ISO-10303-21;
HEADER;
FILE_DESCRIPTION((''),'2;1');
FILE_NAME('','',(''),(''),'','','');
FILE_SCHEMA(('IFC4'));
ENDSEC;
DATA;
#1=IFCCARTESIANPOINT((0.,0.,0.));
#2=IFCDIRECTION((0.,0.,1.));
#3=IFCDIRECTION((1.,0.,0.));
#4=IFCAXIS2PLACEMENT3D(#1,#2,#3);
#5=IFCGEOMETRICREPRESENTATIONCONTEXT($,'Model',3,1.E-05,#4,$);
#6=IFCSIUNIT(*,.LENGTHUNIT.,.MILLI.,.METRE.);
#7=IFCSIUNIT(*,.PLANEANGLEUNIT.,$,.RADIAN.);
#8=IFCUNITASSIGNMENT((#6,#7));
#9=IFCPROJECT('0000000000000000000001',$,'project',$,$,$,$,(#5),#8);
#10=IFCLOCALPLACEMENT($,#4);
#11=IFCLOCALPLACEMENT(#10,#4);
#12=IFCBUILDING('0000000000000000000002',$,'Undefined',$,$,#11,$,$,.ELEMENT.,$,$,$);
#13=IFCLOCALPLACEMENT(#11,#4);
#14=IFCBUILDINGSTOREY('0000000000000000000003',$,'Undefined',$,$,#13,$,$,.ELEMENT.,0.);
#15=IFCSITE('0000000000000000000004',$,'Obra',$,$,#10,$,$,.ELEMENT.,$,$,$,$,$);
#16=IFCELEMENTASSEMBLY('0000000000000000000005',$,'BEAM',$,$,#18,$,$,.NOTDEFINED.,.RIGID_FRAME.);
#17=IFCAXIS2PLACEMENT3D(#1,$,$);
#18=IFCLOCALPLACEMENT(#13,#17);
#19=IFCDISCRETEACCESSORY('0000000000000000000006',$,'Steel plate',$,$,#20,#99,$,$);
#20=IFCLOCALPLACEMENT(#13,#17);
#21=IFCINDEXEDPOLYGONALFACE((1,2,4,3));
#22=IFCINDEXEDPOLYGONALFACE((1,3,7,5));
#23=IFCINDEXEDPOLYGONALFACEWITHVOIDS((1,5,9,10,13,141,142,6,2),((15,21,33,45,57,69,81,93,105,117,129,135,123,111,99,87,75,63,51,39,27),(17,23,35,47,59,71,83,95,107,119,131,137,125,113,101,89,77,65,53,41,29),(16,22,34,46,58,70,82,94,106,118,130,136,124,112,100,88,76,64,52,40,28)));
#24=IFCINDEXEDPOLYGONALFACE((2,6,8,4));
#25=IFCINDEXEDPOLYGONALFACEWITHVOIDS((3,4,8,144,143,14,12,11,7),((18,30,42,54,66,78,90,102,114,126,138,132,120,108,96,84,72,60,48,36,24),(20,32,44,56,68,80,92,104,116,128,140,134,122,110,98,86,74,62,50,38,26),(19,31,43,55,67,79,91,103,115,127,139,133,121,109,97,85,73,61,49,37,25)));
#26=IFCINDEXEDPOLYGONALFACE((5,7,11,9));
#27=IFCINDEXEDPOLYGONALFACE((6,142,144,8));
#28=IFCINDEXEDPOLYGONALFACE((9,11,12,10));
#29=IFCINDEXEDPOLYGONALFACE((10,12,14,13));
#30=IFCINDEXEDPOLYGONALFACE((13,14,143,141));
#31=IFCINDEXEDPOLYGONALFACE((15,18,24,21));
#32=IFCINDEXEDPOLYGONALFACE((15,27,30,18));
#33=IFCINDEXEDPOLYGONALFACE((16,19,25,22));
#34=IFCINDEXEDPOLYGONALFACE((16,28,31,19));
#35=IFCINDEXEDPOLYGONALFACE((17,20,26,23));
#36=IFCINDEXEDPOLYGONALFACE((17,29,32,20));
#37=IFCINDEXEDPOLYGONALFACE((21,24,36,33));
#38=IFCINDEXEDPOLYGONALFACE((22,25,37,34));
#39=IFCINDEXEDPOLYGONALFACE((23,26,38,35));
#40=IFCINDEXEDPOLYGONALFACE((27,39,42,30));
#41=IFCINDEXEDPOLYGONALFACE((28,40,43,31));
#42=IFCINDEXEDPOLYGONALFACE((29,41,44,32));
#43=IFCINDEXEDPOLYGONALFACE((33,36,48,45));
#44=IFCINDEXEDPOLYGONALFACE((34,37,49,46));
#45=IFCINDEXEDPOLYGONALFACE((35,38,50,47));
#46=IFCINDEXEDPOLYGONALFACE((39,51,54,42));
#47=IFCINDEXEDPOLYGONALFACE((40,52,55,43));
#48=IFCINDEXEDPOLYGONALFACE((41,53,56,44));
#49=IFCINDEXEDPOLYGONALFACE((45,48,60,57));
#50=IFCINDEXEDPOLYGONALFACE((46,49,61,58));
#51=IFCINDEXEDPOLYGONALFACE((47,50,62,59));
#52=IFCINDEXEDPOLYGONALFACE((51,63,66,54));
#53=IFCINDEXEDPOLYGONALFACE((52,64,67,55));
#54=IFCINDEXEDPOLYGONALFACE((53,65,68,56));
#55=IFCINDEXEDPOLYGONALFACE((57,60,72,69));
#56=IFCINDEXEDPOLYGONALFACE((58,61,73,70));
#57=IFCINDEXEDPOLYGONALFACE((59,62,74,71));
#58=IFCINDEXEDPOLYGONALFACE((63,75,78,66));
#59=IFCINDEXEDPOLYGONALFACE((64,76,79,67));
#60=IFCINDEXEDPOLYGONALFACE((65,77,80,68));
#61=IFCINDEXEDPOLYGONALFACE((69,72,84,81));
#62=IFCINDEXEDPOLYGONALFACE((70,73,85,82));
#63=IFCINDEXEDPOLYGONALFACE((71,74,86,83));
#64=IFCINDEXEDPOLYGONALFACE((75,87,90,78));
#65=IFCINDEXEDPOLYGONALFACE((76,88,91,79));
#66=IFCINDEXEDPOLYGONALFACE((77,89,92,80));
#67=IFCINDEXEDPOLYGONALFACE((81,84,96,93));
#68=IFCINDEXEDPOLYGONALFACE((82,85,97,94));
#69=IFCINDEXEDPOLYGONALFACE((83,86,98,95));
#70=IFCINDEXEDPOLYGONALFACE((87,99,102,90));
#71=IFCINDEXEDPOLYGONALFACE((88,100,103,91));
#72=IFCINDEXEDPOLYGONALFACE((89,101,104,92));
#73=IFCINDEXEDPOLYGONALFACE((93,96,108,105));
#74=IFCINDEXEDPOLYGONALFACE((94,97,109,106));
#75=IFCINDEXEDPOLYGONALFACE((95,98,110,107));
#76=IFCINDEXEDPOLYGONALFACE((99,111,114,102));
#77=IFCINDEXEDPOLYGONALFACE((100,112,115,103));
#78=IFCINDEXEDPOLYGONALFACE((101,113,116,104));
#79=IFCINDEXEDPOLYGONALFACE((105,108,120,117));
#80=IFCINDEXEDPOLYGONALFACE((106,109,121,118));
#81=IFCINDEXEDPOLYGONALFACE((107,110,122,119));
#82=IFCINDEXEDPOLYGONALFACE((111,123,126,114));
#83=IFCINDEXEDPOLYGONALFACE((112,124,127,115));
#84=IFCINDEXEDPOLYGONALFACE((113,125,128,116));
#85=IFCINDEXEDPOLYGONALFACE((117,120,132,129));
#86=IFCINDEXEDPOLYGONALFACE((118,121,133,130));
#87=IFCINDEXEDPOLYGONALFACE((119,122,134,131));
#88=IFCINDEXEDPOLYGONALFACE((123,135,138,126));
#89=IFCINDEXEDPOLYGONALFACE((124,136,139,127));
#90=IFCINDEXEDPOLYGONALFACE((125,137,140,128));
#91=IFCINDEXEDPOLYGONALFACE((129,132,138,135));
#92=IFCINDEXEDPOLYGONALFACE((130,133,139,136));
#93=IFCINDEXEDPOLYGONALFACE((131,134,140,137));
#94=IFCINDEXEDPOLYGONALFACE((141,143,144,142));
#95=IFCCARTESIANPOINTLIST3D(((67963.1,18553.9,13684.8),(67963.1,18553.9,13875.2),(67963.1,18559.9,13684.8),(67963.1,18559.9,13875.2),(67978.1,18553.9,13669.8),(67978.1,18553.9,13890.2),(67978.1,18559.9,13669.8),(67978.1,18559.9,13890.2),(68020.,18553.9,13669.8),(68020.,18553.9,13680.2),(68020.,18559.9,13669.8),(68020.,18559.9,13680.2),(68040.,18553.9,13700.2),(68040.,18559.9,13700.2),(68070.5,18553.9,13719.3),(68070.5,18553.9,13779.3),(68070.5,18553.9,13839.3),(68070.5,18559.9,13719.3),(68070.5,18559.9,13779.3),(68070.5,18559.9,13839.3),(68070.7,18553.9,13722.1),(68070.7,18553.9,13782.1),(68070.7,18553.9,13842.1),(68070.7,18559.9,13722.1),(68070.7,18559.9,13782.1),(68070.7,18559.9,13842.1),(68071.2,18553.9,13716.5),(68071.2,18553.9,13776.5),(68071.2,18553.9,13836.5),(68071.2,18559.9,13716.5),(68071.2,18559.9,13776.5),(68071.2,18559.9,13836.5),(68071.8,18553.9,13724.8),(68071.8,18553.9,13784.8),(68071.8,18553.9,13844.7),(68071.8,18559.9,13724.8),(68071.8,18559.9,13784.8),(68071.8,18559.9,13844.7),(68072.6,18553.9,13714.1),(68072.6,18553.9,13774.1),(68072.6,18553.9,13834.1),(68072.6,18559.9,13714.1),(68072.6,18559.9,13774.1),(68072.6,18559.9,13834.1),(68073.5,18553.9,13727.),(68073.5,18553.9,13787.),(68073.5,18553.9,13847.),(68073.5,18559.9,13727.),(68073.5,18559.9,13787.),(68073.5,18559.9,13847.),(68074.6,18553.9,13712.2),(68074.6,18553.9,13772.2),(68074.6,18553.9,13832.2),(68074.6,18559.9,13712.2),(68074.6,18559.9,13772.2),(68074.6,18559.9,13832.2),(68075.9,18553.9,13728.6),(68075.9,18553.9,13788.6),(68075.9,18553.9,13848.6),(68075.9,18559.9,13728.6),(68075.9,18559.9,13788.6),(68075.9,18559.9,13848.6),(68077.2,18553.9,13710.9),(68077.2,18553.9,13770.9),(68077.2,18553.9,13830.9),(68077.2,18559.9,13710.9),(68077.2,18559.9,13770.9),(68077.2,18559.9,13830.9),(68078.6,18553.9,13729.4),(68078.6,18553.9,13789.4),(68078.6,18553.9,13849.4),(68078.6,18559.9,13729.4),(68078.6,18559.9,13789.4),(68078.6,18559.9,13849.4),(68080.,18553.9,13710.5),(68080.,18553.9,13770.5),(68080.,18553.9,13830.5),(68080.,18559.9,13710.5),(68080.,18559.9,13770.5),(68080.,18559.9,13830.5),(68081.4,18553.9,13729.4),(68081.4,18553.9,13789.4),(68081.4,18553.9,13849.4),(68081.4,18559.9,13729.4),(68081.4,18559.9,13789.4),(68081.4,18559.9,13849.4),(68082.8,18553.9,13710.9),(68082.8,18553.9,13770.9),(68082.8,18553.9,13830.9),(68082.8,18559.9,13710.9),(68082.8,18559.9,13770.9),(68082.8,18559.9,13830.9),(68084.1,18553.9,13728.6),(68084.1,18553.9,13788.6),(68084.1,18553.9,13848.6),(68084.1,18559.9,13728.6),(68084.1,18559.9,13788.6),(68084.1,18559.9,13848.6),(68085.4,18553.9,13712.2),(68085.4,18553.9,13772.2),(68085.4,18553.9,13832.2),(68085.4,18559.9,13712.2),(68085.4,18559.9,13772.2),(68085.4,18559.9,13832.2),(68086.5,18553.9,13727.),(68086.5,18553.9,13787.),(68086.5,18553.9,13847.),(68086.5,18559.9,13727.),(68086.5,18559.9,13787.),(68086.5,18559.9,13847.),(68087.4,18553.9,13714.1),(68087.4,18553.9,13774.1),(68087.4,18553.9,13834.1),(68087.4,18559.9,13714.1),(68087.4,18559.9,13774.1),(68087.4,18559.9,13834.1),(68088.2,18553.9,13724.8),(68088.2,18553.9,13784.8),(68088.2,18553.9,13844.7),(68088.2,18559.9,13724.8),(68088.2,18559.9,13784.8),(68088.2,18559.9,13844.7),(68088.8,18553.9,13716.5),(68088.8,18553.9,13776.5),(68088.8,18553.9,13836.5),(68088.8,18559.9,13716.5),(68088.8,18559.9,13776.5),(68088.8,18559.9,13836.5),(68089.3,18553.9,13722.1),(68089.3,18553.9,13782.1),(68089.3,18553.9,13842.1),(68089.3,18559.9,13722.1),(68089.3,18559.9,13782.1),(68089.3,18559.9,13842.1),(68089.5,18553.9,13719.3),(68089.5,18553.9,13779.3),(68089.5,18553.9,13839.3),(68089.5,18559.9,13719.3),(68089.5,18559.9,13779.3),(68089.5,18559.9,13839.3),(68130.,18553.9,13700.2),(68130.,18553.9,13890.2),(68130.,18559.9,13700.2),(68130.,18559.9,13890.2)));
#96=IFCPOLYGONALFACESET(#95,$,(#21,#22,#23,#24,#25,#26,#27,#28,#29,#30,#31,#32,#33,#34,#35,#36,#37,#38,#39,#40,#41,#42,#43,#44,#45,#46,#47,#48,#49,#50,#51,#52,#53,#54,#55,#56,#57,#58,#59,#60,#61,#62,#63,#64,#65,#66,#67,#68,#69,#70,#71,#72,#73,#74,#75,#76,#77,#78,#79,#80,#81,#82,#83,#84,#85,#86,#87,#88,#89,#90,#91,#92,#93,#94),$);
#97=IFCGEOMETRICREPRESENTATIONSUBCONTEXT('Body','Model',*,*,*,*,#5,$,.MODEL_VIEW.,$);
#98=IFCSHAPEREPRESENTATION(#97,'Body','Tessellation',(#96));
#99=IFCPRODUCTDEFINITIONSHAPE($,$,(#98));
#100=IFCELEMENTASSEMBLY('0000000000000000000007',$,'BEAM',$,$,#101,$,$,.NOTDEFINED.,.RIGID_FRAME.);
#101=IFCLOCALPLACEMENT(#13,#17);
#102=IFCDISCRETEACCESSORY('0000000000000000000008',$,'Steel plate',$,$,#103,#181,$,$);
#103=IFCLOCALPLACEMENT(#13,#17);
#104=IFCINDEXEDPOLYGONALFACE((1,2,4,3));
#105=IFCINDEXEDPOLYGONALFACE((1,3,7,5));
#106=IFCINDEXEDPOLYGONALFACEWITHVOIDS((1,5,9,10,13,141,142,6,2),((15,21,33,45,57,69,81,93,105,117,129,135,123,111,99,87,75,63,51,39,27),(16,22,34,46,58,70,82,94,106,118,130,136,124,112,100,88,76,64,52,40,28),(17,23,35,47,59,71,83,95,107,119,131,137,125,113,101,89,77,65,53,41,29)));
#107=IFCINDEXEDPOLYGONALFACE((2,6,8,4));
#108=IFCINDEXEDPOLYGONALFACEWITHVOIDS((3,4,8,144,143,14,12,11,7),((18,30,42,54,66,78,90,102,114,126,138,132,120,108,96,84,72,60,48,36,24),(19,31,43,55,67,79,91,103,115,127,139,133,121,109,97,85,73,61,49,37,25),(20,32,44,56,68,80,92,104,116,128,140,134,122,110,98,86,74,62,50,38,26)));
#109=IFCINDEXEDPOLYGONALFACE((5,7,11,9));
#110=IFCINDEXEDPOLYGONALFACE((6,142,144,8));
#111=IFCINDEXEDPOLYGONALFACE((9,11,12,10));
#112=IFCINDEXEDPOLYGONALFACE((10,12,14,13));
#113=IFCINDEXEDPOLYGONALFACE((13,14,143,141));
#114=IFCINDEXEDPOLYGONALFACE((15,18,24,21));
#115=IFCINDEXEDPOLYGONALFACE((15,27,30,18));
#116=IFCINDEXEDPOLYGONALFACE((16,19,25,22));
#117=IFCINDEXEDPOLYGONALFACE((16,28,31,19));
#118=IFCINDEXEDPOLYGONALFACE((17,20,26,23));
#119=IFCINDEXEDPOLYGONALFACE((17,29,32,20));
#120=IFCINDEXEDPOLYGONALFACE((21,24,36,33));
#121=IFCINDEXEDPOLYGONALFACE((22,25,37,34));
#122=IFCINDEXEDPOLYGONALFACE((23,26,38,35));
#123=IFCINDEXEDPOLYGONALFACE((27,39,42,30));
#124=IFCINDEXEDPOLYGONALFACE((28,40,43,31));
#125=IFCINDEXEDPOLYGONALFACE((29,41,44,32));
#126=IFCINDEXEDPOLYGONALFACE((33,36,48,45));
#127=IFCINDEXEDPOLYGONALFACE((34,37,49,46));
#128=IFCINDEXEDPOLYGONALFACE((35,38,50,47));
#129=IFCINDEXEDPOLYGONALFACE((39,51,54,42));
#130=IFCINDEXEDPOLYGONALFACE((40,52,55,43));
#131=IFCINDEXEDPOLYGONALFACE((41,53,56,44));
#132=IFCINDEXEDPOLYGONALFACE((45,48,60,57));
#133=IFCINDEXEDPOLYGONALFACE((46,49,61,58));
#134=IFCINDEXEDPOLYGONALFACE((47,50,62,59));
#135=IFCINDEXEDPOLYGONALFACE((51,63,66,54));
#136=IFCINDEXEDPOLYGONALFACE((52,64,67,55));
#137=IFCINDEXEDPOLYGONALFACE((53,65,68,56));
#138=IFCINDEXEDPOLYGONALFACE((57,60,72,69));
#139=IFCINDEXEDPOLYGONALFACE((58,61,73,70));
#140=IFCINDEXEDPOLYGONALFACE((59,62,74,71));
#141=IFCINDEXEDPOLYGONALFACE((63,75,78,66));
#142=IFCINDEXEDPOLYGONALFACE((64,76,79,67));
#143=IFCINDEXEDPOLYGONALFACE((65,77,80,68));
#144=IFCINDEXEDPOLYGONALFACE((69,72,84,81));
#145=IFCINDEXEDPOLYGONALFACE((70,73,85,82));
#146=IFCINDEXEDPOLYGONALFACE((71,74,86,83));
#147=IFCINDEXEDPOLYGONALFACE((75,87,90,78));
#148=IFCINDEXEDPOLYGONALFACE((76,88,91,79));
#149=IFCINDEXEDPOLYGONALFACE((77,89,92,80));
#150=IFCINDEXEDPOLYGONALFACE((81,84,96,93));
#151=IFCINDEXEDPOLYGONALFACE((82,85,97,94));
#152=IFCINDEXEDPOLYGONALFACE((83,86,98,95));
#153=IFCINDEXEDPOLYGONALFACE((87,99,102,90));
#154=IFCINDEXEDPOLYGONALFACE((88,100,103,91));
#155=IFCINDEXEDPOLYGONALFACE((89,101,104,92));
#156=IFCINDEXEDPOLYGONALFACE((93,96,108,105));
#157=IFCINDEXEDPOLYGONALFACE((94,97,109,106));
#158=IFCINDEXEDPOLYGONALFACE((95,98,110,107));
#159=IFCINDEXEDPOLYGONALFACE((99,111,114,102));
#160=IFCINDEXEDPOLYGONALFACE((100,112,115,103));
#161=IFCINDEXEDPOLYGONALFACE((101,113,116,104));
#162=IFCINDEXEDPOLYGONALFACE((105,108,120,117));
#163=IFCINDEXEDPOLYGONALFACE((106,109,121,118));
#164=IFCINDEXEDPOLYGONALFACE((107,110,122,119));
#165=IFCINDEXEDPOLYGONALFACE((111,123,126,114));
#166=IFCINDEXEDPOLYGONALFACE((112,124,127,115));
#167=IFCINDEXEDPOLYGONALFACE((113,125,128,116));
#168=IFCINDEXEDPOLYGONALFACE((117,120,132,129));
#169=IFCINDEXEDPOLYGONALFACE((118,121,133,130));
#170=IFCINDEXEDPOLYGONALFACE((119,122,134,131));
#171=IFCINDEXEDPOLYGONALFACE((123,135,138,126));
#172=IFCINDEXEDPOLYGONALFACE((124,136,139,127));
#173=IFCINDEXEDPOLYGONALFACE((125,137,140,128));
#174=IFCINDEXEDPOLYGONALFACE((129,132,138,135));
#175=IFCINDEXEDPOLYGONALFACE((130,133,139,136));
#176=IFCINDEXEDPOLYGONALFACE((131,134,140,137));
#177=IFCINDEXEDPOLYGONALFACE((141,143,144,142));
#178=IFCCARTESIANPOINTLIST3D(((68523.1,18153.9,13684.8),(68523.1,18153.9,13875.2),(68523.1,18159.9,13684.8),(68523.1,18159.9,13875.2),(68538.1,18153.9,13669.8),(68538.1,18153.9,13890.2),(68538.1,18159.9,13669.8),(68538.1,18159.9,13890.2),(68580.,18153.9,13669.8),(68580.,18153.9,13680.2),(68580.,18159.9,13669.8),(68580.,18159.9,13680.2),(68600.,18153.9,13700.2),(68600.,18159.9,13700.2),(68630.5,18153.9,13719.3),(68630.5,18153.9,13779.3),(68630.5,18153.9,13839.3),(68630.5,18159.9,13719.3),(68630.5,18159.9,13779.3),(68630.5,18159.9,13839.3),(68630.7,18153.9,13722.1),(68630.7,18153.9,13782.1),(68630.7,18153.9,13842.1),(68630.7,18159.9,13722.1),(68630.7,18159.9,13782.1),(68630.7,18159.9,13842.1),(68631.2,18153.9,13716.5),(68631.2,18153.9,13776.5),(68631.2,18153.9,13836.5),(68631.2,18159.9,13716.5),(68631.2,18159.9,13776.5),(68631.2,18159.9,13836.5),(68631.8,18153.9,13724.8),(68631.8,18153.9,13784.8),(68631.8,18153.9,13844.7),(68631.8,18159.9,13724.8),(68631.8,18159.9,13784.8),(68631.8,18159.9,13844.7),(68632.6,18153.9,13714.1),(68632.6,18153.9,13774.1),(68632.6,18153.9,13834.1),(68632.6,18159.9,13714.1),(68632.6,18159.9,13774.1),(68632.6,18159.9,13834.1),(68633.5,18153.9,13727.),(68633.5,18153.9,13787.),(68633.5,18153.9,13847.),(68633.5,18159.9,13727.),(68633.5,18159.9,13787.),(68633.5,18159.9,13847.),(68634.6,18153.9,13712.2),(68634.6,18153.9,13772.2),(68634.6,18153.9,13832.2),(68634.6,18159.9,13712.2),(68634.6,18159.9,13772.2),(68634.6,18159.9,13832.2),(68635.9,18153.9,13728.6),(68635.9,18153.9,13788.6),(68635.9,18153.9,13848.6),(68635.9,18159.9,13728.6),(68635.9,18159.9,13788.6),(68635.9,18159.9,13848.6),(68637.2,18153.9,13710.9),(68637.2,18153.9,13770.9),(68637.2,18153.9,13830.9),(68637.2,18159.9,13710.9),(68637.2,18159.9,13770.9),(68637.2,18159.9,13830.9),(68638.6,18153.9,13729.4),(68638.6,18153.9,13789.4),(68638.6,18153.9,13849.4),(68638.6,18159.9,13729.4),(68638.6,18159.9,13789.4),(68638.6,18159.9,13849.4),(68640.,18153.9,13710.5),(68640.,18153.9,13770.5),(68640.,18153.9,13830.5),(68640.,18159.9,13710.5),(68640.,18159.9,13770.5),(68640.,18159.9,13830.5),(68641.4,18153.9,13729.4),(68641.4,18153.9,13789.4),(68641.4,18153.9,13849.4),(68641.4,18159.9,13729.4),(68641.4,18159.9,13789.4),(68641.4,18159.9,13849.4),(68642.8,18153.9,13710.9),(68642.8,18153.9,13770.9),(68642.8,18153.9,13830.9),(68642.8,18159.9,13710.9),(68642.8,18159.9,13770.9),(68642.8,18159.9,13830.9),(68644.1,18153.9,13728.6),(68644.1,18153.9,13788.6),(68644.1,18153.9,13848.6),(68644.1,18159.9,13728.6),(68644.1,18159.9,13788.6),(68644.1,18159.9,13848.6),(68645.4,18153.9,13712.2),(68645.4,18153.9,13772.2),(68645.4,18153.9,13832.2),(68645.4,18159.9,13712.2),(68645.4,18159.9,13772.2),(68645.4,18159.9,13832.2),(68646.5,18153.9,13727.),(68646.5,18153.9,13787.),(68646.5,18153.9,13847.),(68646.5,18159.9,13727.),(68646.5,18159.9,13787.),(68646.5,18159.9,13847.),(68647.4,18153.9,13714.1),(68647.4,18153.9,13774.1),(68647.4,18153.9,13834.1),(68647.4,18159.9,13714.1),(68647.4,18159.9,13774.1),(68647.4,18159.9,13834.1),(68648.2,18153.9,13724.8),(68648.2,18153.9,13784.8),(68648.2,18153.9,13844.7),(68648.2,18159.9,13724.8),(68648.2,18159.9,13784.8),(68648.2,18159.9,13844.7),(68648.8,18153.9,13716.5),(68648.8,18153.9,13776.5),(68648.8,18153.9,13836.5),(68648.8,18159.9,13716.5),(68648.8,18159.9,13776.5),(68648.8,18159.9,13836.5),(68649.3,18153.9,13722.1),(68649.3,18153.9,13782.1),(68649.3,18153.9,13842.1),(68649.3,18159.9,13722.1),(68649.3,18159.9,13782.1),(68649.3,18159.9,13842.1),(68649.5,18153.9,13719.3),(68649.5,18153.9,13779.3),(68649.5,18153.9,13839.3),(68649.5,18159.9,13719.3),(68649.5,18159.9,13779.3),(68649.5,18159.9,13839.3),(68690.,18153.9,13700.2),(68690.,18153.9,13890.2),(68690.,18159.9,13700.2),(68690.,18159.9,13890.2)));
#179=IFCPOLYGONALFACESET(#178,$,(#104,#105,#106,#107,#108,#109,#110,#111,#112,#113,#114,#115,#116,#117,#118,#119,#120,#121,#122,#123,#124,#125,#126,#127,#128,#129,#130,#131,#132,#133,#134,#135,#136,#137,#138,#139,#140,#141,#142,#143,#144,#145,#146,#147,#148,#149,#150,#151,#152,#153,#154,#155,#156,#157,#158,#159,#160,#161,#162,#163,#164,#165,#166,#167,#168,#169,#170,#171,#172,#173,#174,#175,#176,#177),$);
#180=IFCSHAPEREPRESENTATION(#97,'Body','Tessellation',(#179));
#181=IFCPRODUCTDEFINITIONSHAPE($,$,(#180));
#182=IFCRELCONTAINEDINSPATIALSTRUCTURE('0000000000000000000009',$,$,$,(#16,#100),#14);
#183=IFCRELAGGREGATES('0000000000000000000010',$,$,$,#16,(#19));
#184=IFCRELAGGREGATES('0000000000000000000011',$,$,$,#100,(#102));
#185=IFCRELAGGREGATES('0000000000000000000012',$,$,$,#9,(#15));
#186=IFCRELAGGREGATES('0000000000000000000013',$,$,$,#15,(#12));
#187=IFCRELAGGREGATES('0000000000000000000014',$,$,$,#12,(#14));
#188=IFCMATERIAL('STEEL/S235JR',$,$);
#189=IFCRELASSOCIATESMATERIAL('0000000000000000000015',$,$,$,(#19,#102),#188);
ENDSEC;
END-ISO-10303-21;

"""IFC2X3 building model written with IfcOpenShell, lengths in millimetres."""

from ifc_helpers import new_model, si_unit, frame, origin_with_axes, origin_2d_with_axis, place, context, subcontext, project, spatial, polyline, circle, outline, extrude, source, transform, mapped, material, element, aggregate, save


model = new_model("IFC2X3")

# Units and contexts
model_context = context("Model", 3, precision=1e-05, world=origin_with_axes())
body_context = subcontext(model_context, "Body", "Model", "MODEL_VIEW")
ifc_project = project(units=[si_unit("LENGTHUNIT", "METRE", prefix="MILLI"), si_unit("PLANEANGLEUNIT", "RADIAN")], contexts=[model_context])

# Site, building, storey
site_placement = place(None, origin_with_axes())
site = spatial("IfcSite", under=ifc_project, at=site_placement, Name="Obra", CompositionType="ELEMENT")
building_placement = place(site_placement, origin_with_axes())
building = spatial("IfcBuilding", under=site, at=building_placement, Name="Undefined", CompositionType="ELEMENT")
storey_placement = place(building_placement, origin_with_axes())
storey = spatial("IfcBuildingStorey", under=building, at=storey_placement, Name="Undefined", CompositionType="ELEMENT", Elevation=0.0)

# Shared definitions
ifc_material_1 = material(Name="STEEL/S235JR")

# Shared definitions
shared_shape_1 = source(origin_with_axes(), body_context, "Body", "SweptSolid", [
    extrude(circle(Radius=9.5, at=origin_2d_with_axis()), frame((0.0, -9.2, 0.0), z_axis=(0.0, 1.0, 0.0), x_axis=(1.0, 0.0, 0.0)), (0.0, 0.0, 1.0), 6.2),
])

# Element assemblies, discrete accessories, openings
assembly_1_placement = place(storey_placement, origin_with_axes())
assembly_1 = element("IfcElementAssembly", 1, at=assembly_1_placement, inside=storey, Name="BEAM", AssemblyPlace="NOTDEFINED", PredefinedType="RIGID_FRAME")
discrete_accessory_1_placement = place(assembly_1_placement, frame((67963.1, 18556.9, 13684.8), z_axis=(0.0, -1.0, 0.0), x_axis=(0.707107, 0.0, -0.707107)))
discrete_accessory_1 = element("IfcDiscreteAccessory", 2, at=discrete_accessory_1_placement, material=ifc_material_1, Name="Steel plate", context=body_context, shape_type="SweptSolid", body=[
    extrude(outline(polyline([(0.0, 0.0), (21.2, 0.0), (50.8, 29.6), (43.5, 37.0), (43.5, 65.3), (107.1, 128.9), (-27.2, 263.3), (-134.6, 155.8), (-134.6, 134.6), (0.0, 0.0)])), frame((0.0, 0.0, -3.0), z_axis=(0.0, 0.0, 1.0), x_axis=(1.0, 0.0, 0.0)), (0.0, 0.0, 1.0), 6.0),
])
shared_shape_2 = source(origin_with_axes(), body_context, "Body", "SweptSolid", [
    extrude(circle(Radius=9.5, at=origin_2d_with_axis()), frame((0.0, -9.2, 0.0), z_axis=(0.0, 1.0, 0.0), x_axis=(1.0, 0.0, 0.0)), (0.0, 0.0, 1.0), 6.2),
])
opening_1_placement = place(assembly_1_placement, frame((68030.0, 18563.0, 13890.2), z_axis=(1.0, 0.0, 0.0), x_axis=(0.0, 0.0, -1.0)))
element("IfcOpeningElement", 3, at=opening_1_placement, cuts=discrete_accessory_1, ObjectType="Opening", context=body_context, shape_type="MappedRepresentation", body=[
    mapped(shared_shape_2, transform((170.2, 0.0, 50.0))),
    mapped(shared_shape_2, transform((110.2, 0.0, 50.0))),
    mapped(shared_shape_2, transform((50.2, 0.0, 50.0))),
])
aggregate(assembly_1, [discrete_accessory_1])
assembly_2_placement = place(storey_placement, origin_with_axes())
assembly_2 = element("IfcElementAssembly", 4, at=assembly_2_placement, inside=storey, Name="BEAM", AssemblyPlace="NOTDEFINED", PredefinedType="RIGID_FRAME")
discrete_accessory_2_placement = place(assembly_2_placement, frame((68523.1, 18156.9, 13684.8), z_axis=(0.0, -1.0, 0.0), x_axis=(0.707107, 0.0, -0.707107)))
discrete_accessory_2 = element("IfcDiscreteAccessory", 5, at=discrete_accessory_2_placement, material=ifc_material_1, Name="Steel plate", context=body_context, shape_type="SweptSolid", body=[
    extrude(outline(polyline([(0.0, 0.0), (21.2, 0.0), (50.8, 29.6), (43.5, 37.0), (43.5, 65.3), (107.1, 128.9), (-27.2, 263.3), (-134.6, 155.8), (-134.6, 134.6), (0.0, 0.0)])), frame((0.0, 0.0, -3.0), z_axis=(0.0, 0.0, 1.0), x_axis=(1.0, 0.0, 0.0)), (0.0, 0.0, 1.0), 6.0),
])
opening_2_placement = place(assembly_2_placement, frame((68590.0, 18163.0, 13890.2), z_axis=(1.0, 0.0, 0.0), x_axis=(0.0, 0.0, -1.0)))
element("IfcOpeningElement", 6, at=opening_2_placement, cuts=discrete_accessory_2, ObjectType="Opening", context=body_context, shape_type="MappedRepresentation", body=[
    mapped(shared_shape_1, transform((170.2, 0.0, 50.0))),
    mapped(shared_shape_1, transform((110.2, 0.0, 50.0))),
    mapped(shared_shape_1, transform((50.2, 0.0, 50.0))),
])
aggregate(assembly_2, [discrete_accessory_2])

save(model, "model.ifc")
